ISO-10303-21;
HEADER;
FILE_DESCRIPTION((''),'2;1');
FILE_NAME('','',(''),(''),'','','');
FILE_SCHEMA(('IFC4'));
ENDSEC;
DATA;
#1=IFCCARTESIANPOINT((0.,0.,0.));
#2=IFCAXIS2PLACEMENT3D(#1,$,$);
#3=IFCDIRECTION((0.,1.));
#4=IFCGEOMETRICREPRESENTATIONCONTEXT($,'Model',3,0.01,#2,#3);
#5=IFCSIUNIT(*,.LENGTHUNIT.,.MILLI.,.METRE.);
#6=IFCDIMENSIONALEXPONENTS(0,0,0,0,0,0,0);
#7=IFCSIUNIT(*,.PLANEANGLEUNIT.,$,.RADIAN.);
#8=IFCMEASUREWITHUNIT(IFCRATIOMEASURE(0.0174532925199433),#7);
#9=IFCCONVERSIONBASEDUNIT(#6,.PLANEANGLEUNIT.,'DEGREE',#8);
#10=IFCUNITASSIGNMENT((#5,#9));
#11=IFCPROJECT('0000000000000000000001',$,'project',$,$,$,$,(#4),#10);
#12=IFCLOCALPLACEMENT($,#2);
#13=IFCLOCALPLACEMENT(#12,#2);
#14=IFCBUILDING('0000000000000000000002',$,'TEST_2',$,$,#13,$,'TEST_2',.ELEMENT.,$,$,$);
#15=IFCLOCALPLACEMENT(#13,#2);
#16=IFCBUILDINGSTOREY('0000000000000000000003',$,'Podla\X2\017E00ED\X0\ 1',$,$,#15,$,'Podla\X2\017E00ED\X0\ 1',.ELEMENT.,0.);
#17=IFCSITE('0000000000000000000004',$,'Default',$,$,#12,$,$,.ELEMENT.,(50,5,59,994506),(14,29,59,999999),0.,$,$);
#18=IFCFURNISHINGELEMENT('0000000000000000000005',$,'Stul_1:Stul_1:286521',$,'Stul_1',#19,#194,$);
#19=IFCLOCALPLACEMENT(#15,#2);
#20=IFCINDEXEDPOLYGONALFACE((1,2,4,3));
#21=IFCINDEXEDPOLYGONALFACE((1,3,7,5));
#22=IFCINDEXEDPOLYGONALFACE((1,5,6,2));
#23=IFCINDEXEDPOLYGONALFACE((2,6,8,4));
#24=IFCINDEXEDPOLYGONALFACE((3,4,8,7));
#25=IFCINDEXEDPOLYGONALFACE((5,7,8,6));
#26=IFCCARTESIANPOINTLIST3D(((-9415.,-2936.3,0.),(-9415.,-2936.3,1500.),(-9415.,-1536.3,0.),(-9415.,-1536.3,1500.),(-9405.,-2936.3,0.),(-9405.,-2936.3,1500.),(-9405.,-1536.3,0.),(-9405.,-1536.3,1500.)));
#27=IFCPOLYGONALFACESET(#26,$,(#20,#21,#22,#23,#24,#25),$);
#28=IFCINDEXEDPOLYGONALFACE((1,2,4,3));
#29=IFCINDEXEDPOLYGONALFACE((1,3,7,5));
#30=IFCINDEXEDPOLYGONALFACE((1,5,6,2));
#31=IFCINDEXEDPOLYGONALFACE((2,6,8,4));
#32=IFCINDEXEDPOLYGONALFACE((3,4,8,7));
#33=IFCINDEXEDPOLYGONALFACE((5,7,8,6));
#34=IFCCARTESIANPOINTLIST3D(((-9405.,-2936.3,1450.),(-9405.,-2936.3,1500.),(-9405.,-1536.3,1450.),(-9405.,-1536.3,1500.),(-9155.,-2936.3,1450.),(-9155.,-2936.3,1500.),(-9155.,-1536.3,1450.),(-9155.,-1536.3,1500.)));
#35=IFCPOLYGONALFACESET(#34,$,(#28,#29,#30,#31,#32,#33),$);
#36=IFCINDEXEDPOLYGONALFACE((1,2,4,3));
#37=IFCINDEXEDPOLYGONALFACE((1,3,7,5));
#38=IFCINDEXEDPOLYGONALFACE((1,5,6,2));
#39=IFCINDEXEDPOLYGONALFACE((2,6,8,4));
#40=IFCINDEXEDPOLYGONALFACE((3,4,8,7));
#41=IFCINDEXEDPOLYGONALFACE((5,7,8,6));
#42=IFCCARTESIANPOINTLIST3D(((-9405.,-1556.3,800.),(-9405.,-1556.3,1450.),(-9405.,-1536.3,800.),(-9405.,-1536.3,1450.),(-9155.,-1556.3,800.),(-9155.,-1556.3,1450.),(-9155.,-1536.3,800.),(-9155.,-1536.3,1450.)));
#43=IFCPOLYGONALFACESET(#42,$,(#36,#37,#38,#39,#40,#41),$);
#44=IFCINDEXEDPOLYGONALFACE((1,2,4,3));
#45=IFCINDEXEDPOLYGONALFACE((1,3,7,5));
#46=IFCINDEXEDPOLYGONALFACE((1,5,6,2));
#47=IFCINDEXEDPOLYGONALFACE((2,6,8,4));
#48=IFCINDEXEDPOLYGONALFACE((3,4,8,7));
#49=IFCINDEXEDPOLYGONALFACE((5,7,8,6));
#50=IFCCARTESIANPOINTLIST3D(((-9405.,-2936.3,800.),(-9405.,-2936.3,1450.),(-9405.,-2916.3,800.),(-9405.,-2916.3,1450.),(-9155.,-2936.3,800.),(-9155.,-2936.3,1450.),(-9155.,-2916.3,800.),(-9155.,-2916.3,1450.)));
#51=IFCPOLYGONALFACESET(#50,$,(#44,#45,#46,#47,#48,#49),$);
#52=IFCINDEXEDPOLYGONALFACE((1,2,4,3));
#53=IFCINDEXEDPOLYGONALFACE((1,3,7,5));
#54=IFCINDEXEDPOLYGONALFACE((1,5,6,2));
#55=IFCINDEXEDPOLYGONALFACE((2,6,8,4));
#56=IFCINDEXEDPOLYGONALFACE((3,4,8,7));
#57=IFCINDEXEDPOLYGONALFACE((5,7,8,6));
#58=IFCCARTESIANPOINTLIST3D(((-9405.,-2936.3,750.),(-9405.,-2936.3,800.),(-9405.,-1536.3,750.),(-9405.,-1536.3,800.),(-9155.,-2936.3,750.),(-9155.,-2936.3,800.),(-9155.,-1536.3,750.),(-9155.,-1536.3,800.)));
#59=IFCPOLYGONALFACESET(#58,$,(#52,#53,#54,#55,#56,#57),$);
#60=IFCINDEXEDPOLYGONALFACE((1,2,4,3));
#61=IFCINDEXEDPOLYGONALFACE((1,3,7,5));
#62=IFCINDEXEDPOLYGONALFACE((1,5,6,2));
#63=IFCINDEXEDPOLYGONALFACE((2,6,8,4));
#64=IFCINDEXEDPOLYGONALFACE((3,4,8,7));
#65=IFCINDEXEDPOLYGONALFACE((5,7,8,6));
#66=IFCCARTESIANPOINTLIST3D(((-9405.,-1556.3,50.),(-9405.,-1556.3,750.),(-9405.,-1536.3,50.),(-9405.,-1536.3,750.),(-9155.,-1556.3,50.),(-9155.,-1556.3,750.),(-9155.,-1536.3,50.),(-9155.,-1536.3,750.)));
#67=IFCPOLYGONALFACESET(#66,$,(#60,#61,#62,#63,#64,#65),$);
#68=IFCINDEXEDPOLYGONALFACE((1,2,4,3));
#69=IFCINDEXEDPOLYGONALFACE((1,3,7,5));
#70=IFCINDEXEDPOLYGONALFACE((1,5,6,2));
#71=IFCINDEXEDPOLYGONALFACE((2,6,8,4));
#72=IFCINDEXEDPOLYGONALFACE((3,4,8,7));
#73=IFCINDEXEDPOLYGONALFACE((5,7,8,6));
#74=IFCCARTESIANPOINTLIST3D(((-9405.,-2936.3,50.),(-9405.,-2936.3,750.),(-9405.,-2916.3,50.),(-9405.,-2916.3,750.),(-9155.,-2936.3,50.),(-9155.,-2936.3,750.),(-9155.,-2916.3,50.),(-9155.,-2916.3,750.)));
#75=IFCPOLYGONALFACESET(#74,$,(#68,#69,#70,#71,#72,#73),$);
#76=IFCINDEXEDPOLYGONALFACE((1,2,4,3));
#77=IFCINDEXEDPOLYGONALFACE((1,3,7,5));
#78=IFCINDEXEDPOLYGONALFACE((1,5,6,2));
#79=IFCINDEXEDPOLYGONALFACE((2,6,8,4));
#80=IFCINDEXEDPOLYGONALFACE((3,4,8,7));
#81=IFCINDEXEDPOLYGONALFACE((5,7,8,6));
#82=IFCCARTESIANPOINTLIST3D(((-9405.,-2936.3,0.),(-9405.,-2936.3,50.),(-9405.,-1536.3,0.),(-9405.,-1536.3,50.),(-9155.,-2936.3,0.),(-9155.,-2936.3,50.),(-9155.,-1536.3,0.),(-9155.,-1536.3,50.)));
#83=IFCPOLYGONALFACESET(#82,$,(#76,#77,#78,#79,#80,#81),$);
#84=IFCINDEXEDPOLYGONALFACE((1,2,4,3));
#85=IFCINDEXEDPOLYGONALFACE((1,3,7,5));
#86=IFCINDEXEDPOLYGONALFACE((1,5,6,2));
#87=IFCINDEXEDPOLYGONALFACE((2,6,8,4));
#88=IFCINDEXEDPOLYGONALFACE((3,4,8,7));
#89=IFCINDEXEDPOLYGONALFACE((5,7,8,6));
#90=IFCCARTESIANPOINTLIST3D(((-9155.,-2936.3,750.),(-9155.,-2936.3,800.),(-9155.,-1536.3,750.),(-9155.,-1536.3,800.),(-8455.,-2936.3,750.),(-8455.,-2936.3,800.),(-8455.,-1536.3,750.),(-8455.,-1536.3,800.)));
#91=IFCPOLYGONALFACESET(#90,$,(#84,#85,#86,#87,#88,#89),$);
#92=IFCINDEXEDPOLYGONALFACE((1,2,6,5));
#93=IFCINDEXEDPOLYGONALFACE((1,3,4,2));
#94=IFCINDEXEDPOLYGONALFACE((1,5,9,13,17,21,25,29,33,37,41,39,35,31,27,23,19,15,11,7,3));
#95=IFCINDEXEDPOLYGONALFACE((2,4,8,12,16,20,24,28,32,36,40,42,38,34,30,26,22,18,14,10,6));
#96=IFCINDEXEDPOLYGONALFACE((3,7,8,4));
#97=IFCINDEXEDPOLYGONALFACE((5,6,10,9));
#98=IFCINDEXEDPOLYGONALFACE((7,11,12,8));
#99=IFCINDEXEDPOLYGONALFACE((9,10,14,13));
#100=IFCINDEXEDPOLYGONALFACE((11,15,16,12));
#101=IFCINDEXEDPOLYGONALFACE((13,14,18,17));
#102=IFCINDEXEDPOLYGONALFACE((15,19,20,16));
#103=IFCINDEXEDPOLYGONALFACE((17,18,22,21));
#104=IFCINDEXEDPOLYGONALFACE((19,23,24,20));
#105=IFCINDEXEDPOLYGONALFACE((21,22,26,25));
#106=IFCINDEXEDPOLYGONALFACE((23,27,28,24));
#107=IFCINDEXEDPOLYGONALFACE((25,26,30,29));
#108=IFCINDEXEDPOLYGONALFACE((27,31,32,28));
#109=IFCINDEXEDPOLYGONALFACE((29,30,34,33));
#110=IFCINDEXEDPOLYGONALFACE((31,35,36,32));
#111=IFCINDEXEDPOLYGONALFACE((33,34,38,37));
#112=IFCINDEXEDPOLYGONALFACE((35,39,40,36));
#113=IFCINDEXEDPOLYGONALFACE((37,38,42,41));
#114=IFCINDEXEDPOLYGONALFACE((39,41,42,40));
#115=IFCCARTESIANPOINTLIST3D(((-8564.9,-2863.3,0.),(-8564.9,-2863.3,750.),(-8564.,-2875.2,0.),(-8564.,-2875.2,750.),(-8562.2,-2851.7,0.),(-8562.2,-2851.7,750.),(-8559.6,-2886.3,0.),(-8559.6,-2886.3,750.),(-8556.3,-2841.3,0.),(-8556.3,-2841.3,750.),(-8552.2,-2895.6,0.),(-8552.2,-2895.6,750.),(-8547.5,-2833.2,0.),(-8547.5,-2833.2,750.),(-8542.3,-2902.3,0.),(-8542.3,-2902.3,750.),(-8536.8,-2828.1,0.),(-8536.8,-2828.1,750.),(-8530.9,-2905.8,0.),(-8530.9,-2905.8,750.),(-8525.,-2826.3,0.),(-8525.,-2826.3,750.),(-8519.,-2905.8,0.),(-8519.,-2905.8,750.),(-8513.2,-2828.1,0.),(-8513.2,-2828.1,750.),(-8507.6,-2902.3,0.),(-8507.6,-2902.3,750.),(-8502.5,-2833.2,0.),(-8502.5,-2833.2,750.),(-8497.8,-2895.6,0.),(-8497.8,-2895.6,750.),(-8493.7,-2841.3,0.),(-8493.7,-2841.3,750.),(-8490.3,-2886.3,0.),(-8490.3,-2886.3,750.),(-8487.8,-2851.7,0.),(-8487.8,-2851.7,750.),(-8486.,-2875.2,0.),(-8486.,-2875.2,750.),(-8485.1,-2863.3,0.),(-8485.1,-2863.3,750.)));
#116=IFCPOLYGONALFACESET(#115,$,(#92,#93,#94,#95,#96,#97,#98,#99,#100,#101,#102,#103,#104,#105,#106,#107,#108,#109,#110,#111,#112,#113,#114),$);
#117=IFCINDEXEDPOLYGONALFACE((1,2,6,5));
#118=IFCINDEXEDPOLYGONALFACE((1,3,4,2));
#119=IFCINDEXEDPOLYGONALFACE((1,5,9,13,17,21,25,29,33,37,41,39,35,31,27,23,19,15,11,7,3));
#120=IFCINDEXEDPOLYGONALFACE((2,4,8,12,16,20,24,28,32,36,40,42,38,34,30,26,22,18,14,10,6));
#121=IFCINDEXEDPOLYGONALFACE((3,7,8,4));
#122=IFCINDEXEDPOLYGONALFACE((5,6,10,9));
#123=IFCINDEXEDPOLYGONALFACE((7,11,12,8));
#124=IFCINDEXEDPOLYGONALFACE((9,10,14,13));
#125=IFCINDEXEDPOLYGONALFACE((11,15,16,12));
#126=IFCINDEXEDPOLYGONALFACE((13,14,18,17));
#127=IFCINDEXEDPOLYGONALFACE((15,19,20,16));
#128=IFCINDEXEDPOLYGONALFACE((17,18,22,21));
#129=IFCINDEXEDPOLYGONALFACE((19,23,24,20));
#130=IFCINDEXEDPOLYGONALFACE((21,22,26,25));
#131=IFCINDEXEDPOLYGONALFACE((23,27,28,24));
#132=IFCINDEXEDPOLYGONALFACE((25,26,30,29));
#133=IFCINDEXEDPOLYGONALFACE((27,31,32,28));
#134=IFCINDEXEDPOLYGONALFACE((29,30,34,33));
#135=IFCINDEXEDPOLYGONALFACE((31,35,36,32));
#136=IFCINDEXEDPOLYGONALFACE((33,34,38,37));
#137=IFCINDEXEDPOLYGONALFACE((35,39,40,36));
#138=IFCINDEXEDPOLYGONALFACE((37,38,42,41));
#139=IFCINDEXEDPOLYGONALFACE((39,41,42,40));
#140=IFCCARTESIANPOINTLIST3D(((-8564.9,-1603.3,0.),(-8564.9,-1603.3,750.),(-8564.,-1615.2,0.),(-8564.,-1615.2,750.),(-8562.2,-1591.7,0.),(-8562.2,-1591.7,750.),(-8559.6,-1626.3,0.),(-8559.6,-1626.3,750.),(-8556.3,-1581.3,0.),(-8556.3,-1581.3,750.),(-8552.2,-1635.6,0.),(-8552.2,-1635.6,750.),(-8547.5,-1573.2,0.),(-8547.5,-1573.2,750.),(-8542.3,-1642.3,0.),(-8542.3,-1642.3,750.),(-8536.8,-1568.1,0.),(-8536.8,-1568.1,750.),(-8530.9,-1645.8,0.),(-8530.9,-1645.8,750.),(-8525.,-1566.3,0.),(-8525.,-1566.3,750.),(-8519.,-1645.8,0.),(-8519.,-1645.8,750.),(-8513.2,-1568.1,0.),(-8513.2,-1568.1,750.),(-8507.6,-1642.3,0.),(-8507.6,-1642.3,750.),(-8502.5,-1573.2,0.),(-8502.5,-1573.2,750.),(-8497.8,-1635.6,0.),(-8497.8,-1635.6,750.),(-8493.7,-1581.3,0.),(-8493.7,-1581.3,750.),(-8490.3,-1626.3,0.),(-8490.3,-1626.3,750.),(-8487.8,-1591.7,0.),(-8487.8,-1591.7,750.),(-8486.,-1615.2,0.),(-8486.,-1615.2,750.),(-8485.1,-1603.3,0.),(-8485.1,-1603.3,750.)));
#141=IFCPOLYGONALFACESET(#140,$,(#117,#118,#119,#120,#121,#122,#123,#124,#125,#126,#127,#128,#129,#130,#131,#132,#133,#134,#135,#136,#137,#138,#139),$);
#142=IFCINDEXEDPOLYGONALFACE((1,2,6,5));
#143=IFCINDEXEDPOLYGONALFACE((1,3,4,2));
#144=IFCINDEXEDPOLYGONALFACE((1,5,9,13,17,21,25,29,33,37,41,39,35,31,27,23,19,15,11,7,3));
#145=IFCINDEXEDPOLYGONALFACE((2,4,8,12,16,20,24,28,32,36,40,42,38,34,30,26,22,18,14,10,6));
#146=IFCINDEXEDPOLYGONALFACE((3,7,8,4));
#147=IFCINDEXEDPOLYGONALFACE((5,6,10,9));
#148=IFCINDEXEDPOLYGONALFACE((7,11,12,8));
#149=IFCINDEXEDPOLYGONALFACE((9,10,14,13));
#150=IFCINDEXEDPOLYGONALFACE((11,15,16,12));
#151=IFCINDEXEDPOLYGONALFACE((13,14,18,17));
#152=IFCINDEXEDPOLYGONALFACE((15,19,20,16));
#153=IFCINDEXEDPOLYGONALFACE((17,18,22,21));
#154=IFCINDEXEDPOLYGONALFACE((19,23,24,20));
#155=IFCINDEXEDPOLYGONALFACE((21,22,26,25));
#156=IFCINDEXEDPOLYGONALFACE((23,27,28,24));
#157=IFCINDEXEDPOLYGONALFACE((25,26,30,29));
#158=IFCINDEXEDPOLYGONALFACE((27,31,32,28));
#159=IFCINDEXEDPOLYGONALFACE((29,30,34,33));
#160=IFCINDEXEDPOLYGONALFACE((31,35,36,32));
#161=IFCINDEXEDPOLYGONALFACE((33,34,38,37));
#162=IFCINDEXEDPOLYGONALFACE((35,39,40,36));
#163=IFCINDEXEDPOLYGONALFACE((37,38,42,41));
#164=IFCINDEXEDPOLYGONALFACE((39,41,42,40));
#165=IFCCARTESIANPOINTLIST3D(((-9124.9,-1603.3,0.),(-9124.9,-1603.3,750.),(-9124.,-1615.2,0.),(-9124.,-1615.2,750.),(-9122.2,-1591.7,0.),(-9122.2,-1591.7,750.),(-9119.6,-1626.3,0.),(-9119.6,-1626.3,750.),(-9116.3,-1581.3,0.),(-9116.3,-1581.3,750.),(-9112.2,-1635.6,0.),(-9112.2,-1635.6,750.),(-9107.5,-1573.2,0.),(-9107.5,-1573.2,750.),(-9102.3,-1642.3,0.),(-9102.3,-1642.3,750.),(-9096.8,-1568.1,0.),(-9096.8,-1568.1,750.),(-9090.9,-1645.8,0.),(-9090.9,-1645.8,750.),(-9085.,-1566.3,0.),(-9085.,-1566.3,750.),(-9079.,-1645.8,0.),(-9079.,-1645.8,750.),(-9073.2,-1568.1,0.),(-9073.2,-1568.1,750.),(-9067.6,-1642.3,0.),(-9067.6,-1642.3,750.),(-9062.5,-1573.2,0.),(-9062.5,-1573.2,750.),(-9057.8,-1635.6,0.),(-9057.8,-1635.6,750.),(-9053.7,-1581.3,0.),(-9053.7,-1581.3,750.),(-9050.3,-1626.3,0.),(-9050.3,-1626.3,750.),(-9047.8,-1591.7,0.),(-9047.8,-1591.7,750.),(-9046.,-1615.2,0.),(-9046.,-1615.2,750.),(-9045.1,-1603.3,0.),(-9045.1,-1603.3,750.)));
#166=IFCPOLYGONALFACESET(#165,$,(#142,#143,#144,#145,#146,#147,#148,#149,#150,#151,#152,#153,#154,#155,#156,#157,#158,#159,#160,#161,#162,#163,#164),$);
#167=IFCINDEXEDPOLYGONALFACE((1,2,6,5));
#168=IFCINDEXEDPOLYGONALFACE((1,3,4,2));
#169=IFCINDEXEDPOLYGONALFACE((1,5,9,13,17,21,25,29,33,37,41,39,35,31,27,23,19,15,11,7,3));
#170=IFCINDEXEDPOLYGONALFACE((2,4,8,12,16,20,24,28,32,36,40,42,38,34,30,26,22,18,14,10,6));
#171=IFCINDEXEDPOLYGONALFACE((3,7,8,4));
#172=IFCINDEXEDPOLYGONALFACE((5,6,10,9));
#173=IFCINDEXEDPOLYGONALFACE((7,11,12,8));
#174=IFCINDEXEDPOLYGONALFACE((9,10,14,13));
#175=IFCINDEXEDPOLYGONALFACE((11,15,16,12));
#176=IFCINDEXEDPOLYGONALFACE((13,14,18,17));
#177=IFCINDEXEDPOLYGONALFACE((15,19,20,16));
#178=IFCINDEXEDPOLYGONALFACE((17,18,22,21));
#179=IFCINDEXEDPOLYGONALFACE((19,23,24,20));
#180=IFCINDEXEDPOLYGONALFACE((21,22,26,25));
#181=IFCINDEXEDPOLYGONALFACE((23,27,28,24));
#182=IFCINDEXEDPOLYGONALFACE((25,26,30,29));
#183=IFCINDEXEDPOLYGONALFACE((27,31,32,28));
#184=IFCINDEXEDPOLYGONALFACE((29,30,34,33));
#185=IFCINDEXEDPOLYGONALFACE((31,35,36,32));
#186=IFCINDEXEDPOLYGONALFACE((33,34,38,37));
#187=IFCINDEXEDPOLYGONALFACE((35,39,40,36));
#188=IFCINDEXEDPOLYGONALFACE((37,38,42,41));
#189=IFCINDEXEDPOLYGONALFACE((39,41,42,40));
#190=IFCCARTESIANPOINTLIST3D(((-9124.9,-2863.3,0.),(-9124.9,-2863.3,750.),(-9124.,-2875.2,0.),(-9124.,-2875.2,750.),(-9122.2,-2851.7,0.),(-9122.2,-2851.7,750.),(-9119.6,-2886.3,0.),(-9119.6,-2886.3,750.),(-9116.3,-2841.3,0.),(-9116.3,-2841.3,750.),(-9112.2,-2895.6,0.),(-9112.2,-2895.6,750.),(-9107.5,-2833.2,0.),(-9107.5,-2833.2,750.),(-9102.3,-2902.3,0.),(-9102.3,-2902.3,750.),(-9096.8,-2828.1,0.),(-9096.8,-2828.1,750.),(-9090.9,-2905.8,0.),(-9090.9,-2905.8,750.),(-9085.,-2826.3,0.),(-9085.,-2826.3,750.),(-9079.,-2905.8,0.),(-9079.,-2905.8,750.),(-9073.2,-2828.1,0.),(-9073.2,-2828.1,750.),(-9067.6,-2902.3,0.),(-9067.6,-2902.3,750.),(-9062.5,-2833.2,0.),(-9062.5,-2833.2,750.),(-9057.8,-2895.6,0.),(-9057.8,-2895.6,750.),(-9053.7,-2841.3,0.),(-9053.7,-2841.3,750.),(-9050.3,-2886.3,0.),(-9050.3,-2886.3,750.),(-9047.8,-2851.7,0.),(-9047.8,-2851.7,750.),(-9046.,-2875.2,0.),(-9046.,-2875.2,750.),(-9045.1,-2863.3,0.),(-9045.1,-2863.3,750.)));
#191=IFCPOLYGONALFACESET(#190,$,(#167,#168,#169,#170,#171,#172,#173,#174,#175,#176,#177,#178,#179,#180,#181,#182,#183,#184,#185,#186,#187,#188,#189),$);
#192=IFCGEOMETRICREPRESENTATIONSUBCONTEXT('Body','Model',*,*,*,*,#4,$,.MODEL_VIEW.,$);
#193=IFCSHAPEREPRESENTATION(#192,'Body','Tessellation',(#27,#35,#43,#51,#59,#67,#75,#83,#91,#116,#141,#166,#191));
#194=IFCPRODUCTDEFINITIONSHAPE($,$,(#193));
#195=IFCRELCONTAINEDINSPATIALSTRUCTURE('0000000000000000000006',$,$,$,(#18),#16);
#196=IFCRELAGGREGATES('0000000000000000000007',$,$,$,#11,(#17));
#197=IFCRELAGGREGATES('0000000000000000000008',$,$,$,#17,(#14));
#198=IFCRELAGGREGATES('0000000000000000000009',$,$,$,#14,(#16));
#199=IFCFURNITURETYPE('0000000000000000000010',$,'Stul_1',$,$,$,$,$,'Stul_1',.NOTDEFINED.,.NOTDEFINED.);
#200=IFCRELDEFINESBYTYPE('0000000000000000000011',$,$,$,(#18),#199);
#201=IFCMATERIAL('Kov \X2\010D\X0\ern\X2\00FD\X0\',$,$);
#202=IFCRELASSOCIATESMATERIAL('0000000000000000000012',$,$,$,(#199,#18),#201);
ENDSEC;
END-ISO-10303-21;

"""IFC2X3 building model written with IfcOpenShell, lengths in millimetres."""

from ifc_helpers import new_model, entity, si_unit, converted_unit, direction, frame, frame_2d, origin, origin_2d_with_axis, place, context, subcontext, project, spatial, rectangle, circle, extrude, source, transform, mapped, material, type_object, type_shapes, element, save


model = new_model("IFC2X3")

# Units and contexts
model_context = context("Model", 3, precision=0.01, world=origin(), true_north=direction((0.0, 1.0)))
body_context = subcontext(model_context, "Body", "Model", "MODEL_VIEW")
ifc_project = project(units=[si_unit("LENGTHUNIT", "METRE", prefix="MILLI"), converted_unit("PLANEANGLEUNIT", "DEGREE", entity("IfcRatioMeasure", 0.0174532925199433), si_unit("PLANEANGLEUNIT", "RADIAN"), dimensions=[0, 0, 0, 0, 0, 0, 0])], contexts=[model_context])

# Site, building, storey
site_placement = place(None, origin())
site = spatial("IfcSite", under=ifc_project, at=site_placement, Name="Default", CompositionType="ELEMENT", RefLatitude=(50, 5, 59, 994506), RefLongitude=(14, 29, 59, 999999), RefElevation=0.0)
building_placement = place(site_placement, origin())
building = spatial("IfcBuilding", under=site, at=building_placement, Name="TEST_2", LongName="TEST_2", CompositionType="ELEMENT")
storey_placement = place(building_placement, origin())
storey = spatial("IfcBuildingStorey", under=building, at=storey_placement, Name="Podlaží 1", LongName="Podlaží 1", CompositionType="ELEMENT", Elevation=0.0)

# Furnishing element
ifc_material_1 = material(Name="Kov černý")
furniture_type = type_object("IfcFurnitureType", Name="Stul_1", ElementType="Stul_1", material=ifc_material_1)
shared_shape_1 = source(origin(), body_context, "Body", "SweptSolid", [
    extrude(rectangle(XDim=1400.0, YDim=10.0, at=origin_2d_with_axis()), frame((0.0, 605.0, 0.0), z_axis=(0.0, 0.0, 1.0), x_axis=(-1.0, 0.0, 0.0)), (0.0, 0.0, 1.0), 1500.0),
    extrude(rectangle(XDim=1400.0, YDim=250.0, at=frame_2d((0.0, 0.0), x_axis=(1.0, 0.0))), frame((0.0, 475.0, 1450.0), z_axis=(0.0, 0.0, 1.0), x_axis=(-1.0, 0.0, 0.0)), (0.0, 0.0, 1.0), 50.0),
    extrude(rectangle(XDim=20.0, YDim=250.0, at=origin_2d_with_axis()), frame((690.0, 475.0, 800.0), z_axis=(0.0, 0.0, 1.0), x_axis=(-1.0, 0.0, 0.0)), (0.0, 0.0, 1.0), 650.0),
    extrude(rectangle(XDim=20.0, YDim=250.0, at=frame_2d((0.0, 0.0), x_axis=(1.0, 0.0))), frame((-690.0, 475.0, 800.0), z_axis=(0.0, 0.0, 1.0), x_axis=(-1.0, 0.0, 0.0)), (0.0, 0.0, 1.0), 650.0),
    extrude(rectangle(XDim=1400.0, YDim=250.0, at=origin_2d_with_axis()), frame((0.0, 475.0, 750.0), z_axis=(0.0, 0.0, 1.0), x_axis=(-1.0, 0.0, 0.0)), (0.0, 0.0, 1.0), 50.0),
    extrude(rectangle(XDim=20.0, YDim=250.0, at=origin_2d_with_axis()), frame((690.0, 475.0, 50.0), z_axis=(0.0, 0.0, 1.0), x_axis=(-1.0, 0.0, 0.0)), (0.0, 0.0, 1.0), 700.0),
    extrude(rectangle(XDim=20.0, YDim=250.0, at=frame_2d((0.0, 0.0), x_axis=(1.0, 0.0))), frame((-690.0, 475.0, 50.0), z_axis=(0.0, 0.0, 1.0), x_axis=(-1.0, 0.0, 0.0)), (0.0, 0.0, 1.0), 700.0),
    extrude(rectangle(XDim=1400.0, YDim=250.0, at=origin_2d_with_axis()), frame((0.0, 475.0, 0.0), z_axis=(0.0, 0.0, 1.0), x_axis=(-1.0, 0.0, 0.0)), (0.0, 0.0, 1.0), 50.0),
    extrude(rectangle(XDim=1400.0, YDim=700.0, at=origin_2d_with_axis()), frame((0.0, 0.0, 750.0), z_axis=(0.0, 0.0, 1.0), x_axis=(-1.0, 0.0, 0.0)), (0.0, 0.0, 1.0), 50.0),
    extrude(circle(Radius=40.0, at=frame_2d((0.0, 0.0), x_axis=(1.0, 0.0))), frame((-630.0, -280.0, 0.0)), (0.0, 0.0, 1.0), 750.0),
    extrude(circle(Radius=40.0, at=frame_2d((0.0, 0.0), x_axis=(1.0, 0.0))), frame((630.0, -280.0, 0.0)), (0.0, 0.0, 1.0), 750.0),
    extrude(circle(Radius=40.0, at=frame_2d((0.0, 0.0), x_axis=(1.0, 0.0))), frame((630.0, 280.0, 0.0)), (0.0, 0.0, 1.0), 750.0),
    extrude(circle(Radius=40.0, at=frame_2d((0.0, 0.0), x_axis=(1.0, 0.0))), frame((-630.0, 280.0, 0.0)), (0.0, 0.0, 1.0), 750.0),
])
type_shapes(furniture_type, [shared_shape_1])
for number, where, z_axis, x_axis, name in (
    (1, (-8805.0, -2236.3, 0.0), (0.0, 0.0, 1.0), (0.0, 1.0, 0.0), "Stul_1:Stul_1:286521"),
):
    element("IfcFurnishingElement", number, at=place(storey_placement, frame(where, z_axis=z_axis, x_axis=x_axis)), inside=storey, type_object=furniture_type, material=ifc_material_1, Name=name, ObjectType="Stul_1", context=body_context, shape_type="MappedRepresentation", body=[
        mapped(shared_shape_1, transform((0.0, 0.0, 0.0), scale=1.0)),
    ])

save(model, "model.ifc")
